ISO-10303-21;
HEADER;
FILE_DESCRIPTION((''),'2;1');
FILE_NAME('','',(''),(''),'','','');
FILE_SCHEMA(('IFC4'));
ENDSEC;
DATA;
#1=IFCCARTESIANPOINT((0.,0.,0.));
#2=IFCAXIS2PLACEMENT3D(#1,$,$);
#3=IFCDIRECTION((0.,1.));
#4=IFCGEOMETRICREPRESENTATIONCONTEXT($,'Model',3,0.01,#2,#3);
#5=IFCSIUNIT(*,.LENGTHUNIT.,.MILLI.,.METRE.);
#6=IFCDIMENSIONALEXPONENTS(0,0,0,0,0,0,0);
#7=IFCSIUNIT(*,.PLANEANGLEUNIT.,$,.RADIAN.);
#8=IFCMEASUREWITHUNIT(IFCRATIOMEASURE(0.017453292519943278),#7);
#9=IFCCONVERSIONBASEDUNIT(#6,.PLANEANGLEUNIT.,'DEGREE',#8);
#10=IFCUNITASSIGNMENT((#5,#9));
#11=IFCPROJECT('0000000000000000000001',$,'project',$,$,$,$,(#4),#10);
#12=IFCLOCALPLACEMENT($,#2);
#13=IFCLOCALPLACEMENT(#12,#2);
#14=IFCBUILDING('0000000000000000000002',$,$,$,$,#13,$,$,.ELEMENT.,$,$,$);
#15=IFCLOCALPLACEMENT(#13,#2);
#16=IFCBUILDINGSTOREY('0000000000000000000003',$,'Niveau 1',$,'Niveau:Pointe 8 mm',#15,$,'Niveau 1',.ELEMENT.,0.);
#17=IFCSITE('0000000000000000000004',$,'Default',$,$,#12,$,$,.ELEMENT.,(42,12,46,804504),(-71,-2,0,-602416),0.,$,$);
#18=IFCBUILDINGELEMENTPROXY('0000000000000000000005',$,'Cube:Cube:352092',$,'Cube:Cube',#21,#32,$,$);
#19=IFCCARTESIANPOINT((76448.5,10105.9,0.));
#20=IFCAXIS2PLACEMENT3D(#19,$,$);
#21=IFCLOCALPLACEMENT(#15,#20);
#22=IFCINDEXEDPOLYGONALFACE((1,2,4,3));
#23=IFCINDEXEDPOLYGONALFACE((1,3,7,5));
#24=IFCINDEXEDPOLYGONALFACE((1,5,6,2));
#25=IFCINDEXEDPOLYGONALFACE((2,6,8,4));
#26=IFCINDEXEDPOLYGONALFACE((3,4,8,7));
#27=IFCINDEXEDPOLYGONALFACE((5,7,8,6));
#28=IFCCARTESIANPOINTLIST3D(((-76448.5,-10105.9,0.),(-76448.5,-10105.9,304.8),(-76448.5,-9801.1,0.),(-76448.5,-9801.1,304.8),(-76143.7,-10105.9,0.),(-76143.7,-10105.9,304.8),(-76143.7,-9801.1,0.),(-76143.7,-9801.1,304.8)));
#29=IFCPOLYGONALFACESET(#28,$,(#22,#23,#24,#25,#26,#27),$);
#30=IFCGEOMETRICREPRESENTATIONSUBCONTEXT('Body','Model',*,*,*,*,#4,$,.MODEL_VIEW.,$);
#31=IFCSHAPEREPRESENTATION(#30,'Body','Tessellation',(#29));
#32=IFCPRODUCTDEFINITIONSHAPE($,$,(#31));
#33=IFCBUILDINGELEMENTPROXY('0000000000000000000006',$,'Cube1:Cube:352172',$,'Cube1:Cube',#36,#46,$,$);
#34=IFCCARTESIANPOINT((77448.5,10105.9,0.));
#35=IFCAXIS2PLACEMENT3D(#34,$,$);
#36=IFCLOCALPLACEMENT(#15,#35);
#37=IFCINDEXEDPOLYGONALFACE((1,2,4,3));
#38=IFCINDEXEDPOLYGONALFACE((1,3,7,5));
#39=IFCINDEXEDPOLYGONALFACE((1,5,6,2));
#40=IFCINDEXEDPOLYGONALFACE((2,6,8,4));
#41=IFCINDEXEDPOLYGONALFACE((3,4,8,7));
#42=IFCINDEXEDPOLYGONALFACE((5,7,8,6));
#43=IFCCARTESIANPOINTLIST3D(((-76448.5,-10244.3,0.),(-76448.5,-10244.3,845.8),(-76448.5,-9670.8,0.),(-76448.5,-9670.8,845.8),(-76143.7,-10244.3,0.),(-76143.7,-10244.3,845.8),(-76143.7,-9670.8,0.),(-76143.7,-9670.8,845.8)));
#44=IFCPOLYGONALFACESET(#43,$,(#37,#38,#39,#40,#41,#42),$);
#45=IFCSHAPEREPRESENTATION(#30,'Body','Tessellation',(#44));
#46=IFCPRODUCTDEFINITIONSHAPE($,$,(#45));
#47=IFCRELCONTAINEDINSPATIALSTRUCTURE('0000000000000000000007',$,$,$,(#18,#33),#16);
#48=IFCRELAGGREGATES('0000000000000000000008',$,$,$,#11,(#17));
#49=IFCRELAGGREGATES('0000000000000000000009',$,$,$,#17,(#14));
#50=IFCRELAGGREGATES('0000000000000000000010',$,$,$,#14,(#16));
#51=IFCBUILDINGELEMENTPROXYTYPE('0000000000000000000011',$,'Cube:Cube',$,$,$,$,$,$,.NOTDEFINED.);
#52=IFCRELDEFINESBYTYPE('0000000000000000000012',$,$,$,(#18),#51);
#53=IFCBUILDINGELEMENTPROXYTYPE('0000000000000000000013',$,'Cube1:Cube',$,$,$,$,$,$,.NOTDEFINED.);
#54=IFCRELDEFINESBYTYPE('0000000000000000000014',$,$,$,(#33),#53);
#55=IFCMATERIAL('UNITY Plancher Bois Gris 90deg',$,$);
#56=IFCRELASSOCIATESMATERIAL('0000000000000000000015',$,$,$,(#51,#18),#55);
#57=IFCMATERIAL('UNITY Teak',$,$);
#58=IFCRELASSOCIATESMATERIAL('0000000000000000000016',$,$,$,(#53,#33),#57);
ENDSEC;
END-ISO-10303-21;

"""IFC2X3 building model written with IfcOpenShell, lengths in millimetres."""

from ifc_helpers import new_model, entity, si_unit, converted_unit, direction, frame, frame_2d, origin, origin_2d_with_axis, place, context, subcontext, project, spatial, rectangle, extrude, source, transform, mapped, material, type_object, type_shapes, element, save


model = new_model("IFC2X3")

# Units and contexts
model_context = context("Model", 3, precision=0.01, world=origin(), true_north=direction((0.0, 1.0)))
body_context = subcontext(model_context, "Body", "Model", "MODEL_VIEW")
ifc_project = project(units=[si_unit("LENGTHUNIT", "METRE", prefix="MILLI"), converted_unit("PLANEANGLEUNIT", "DEGREE", entity("IfcRatioMeasure", 0.017453292519943278), si_unit("PLANEANGLEUNIT", "RADIAN"), dimensions=[0, 0, 0, 0, 0, 0, 0])], contexts=[model_context])

# Site, building, storey
site_placement = place(None, origin())
site = spatial("IfcSite", under=ifc_project, at=site_placement, Name="Default", CompositionType="ELEMENT", RefLatitude=(42, 12, 46, 804504), RefLongitude=(-71, -2, 0, -602416), RefElevation=0.0)
building_placement = place(site_placement, origin())
building = spatial("IfcBuilding", under=site, at=building_placement, CompositionType="ELEMENT")
storey_placement = place(building_placement, origin())
storey = spatial("IfcBuildingStorey", under=building, at=storey_placement, Name="Niveau 1", ObjectType="Niveau:Pointe 8 mm", LongName="Niveau 1", CompositionType="ELEMENT", Elevation=0.0)

# Shared definitions
ifc_material_1 = material(Name="UNITY Plancher Bois Gris 90deg")

# Building element proxies
building_element_proxy_type_1 = type_object("IfcBuildingElementProxyType", Name="Cube:Cube", PredefinedType="NOTDEFINED", material=ifc_material_1)
shared_shape_1 = source(origin(), body_context, "Body", "SweptSolid", [
    extrude(rectangle(XDim=304.8, YDim=304.8, at=origin_2d_with_axis()), frame((-76296.1, -9953.5, 0.0), z_axis=(0.0, 0.0, 1.0), x_axis=(0.0, -1.0, 0.0)), (0.0, 0.0, 1.0), 304.8),
])
type_shapes(building_element_proxy_type_1, [shared_shape_1])
proxy_1_placement = place(storey_placement, frame((76448.5, 10105.9, 0.0)))
element("IfcBuildingElementProxy", 1, at=proxy_1_placement, inside=storey, type_object=building_element_proxy_type_1, material=ifc_material_1, Name="Cube:Cube:352092", ObjectType="Cube:Cube", context=body_context, shape_type="MappedRepresentation", body=[
    mapped(shared_shape_1, transform((0.0, 0.0, 0.0), scale=1.0)),
])
ifc_material_2 = material(Name="UNITY Teak")
building_element_proxy_type_2 = type_object("IfcBuildingElementProxyType", Name="Cube1:Cube", PredefinedType="NOTDEFINED", material=ifc_material_2)
shared_shape_2 = source(origin(), body_context, "Body", "SweptSolid", [
    extrude(rectangle(XDim=573.5, YDim=304.8, at=frame_2d((0.0, 0.0), x_axis=(1.0, 0.0))), frame((-76296.1, -9957.5, 0.0), z_axis=(0.0, 0.0, 1.0), x_axis=(0.0, -1.0, 0.0)), (0.0, 0.0, 1.0), 845.8),
])
type_shapes(building_element_proxy_type_2, [shared_shape_2])
proxy_2_placement = place(storey_placement, frame((77448.5, 10105.9, 0.0)))
element("IfcBuildingElementProxy", 2, at=proxy_2_placement, inside=storey, type_object=building_element_proxy_type_2, material=ifc_material_2, Name="Cube1:Cube:352172", ObjectType="Cube1:Cube", context=body_context, shape_type="MappedRepresentation", body=[
    mapped(shared_shape_2, transform((0.0, 0.0, 0.0), scale=1.0)),
])

save(model, "model.ifc")
